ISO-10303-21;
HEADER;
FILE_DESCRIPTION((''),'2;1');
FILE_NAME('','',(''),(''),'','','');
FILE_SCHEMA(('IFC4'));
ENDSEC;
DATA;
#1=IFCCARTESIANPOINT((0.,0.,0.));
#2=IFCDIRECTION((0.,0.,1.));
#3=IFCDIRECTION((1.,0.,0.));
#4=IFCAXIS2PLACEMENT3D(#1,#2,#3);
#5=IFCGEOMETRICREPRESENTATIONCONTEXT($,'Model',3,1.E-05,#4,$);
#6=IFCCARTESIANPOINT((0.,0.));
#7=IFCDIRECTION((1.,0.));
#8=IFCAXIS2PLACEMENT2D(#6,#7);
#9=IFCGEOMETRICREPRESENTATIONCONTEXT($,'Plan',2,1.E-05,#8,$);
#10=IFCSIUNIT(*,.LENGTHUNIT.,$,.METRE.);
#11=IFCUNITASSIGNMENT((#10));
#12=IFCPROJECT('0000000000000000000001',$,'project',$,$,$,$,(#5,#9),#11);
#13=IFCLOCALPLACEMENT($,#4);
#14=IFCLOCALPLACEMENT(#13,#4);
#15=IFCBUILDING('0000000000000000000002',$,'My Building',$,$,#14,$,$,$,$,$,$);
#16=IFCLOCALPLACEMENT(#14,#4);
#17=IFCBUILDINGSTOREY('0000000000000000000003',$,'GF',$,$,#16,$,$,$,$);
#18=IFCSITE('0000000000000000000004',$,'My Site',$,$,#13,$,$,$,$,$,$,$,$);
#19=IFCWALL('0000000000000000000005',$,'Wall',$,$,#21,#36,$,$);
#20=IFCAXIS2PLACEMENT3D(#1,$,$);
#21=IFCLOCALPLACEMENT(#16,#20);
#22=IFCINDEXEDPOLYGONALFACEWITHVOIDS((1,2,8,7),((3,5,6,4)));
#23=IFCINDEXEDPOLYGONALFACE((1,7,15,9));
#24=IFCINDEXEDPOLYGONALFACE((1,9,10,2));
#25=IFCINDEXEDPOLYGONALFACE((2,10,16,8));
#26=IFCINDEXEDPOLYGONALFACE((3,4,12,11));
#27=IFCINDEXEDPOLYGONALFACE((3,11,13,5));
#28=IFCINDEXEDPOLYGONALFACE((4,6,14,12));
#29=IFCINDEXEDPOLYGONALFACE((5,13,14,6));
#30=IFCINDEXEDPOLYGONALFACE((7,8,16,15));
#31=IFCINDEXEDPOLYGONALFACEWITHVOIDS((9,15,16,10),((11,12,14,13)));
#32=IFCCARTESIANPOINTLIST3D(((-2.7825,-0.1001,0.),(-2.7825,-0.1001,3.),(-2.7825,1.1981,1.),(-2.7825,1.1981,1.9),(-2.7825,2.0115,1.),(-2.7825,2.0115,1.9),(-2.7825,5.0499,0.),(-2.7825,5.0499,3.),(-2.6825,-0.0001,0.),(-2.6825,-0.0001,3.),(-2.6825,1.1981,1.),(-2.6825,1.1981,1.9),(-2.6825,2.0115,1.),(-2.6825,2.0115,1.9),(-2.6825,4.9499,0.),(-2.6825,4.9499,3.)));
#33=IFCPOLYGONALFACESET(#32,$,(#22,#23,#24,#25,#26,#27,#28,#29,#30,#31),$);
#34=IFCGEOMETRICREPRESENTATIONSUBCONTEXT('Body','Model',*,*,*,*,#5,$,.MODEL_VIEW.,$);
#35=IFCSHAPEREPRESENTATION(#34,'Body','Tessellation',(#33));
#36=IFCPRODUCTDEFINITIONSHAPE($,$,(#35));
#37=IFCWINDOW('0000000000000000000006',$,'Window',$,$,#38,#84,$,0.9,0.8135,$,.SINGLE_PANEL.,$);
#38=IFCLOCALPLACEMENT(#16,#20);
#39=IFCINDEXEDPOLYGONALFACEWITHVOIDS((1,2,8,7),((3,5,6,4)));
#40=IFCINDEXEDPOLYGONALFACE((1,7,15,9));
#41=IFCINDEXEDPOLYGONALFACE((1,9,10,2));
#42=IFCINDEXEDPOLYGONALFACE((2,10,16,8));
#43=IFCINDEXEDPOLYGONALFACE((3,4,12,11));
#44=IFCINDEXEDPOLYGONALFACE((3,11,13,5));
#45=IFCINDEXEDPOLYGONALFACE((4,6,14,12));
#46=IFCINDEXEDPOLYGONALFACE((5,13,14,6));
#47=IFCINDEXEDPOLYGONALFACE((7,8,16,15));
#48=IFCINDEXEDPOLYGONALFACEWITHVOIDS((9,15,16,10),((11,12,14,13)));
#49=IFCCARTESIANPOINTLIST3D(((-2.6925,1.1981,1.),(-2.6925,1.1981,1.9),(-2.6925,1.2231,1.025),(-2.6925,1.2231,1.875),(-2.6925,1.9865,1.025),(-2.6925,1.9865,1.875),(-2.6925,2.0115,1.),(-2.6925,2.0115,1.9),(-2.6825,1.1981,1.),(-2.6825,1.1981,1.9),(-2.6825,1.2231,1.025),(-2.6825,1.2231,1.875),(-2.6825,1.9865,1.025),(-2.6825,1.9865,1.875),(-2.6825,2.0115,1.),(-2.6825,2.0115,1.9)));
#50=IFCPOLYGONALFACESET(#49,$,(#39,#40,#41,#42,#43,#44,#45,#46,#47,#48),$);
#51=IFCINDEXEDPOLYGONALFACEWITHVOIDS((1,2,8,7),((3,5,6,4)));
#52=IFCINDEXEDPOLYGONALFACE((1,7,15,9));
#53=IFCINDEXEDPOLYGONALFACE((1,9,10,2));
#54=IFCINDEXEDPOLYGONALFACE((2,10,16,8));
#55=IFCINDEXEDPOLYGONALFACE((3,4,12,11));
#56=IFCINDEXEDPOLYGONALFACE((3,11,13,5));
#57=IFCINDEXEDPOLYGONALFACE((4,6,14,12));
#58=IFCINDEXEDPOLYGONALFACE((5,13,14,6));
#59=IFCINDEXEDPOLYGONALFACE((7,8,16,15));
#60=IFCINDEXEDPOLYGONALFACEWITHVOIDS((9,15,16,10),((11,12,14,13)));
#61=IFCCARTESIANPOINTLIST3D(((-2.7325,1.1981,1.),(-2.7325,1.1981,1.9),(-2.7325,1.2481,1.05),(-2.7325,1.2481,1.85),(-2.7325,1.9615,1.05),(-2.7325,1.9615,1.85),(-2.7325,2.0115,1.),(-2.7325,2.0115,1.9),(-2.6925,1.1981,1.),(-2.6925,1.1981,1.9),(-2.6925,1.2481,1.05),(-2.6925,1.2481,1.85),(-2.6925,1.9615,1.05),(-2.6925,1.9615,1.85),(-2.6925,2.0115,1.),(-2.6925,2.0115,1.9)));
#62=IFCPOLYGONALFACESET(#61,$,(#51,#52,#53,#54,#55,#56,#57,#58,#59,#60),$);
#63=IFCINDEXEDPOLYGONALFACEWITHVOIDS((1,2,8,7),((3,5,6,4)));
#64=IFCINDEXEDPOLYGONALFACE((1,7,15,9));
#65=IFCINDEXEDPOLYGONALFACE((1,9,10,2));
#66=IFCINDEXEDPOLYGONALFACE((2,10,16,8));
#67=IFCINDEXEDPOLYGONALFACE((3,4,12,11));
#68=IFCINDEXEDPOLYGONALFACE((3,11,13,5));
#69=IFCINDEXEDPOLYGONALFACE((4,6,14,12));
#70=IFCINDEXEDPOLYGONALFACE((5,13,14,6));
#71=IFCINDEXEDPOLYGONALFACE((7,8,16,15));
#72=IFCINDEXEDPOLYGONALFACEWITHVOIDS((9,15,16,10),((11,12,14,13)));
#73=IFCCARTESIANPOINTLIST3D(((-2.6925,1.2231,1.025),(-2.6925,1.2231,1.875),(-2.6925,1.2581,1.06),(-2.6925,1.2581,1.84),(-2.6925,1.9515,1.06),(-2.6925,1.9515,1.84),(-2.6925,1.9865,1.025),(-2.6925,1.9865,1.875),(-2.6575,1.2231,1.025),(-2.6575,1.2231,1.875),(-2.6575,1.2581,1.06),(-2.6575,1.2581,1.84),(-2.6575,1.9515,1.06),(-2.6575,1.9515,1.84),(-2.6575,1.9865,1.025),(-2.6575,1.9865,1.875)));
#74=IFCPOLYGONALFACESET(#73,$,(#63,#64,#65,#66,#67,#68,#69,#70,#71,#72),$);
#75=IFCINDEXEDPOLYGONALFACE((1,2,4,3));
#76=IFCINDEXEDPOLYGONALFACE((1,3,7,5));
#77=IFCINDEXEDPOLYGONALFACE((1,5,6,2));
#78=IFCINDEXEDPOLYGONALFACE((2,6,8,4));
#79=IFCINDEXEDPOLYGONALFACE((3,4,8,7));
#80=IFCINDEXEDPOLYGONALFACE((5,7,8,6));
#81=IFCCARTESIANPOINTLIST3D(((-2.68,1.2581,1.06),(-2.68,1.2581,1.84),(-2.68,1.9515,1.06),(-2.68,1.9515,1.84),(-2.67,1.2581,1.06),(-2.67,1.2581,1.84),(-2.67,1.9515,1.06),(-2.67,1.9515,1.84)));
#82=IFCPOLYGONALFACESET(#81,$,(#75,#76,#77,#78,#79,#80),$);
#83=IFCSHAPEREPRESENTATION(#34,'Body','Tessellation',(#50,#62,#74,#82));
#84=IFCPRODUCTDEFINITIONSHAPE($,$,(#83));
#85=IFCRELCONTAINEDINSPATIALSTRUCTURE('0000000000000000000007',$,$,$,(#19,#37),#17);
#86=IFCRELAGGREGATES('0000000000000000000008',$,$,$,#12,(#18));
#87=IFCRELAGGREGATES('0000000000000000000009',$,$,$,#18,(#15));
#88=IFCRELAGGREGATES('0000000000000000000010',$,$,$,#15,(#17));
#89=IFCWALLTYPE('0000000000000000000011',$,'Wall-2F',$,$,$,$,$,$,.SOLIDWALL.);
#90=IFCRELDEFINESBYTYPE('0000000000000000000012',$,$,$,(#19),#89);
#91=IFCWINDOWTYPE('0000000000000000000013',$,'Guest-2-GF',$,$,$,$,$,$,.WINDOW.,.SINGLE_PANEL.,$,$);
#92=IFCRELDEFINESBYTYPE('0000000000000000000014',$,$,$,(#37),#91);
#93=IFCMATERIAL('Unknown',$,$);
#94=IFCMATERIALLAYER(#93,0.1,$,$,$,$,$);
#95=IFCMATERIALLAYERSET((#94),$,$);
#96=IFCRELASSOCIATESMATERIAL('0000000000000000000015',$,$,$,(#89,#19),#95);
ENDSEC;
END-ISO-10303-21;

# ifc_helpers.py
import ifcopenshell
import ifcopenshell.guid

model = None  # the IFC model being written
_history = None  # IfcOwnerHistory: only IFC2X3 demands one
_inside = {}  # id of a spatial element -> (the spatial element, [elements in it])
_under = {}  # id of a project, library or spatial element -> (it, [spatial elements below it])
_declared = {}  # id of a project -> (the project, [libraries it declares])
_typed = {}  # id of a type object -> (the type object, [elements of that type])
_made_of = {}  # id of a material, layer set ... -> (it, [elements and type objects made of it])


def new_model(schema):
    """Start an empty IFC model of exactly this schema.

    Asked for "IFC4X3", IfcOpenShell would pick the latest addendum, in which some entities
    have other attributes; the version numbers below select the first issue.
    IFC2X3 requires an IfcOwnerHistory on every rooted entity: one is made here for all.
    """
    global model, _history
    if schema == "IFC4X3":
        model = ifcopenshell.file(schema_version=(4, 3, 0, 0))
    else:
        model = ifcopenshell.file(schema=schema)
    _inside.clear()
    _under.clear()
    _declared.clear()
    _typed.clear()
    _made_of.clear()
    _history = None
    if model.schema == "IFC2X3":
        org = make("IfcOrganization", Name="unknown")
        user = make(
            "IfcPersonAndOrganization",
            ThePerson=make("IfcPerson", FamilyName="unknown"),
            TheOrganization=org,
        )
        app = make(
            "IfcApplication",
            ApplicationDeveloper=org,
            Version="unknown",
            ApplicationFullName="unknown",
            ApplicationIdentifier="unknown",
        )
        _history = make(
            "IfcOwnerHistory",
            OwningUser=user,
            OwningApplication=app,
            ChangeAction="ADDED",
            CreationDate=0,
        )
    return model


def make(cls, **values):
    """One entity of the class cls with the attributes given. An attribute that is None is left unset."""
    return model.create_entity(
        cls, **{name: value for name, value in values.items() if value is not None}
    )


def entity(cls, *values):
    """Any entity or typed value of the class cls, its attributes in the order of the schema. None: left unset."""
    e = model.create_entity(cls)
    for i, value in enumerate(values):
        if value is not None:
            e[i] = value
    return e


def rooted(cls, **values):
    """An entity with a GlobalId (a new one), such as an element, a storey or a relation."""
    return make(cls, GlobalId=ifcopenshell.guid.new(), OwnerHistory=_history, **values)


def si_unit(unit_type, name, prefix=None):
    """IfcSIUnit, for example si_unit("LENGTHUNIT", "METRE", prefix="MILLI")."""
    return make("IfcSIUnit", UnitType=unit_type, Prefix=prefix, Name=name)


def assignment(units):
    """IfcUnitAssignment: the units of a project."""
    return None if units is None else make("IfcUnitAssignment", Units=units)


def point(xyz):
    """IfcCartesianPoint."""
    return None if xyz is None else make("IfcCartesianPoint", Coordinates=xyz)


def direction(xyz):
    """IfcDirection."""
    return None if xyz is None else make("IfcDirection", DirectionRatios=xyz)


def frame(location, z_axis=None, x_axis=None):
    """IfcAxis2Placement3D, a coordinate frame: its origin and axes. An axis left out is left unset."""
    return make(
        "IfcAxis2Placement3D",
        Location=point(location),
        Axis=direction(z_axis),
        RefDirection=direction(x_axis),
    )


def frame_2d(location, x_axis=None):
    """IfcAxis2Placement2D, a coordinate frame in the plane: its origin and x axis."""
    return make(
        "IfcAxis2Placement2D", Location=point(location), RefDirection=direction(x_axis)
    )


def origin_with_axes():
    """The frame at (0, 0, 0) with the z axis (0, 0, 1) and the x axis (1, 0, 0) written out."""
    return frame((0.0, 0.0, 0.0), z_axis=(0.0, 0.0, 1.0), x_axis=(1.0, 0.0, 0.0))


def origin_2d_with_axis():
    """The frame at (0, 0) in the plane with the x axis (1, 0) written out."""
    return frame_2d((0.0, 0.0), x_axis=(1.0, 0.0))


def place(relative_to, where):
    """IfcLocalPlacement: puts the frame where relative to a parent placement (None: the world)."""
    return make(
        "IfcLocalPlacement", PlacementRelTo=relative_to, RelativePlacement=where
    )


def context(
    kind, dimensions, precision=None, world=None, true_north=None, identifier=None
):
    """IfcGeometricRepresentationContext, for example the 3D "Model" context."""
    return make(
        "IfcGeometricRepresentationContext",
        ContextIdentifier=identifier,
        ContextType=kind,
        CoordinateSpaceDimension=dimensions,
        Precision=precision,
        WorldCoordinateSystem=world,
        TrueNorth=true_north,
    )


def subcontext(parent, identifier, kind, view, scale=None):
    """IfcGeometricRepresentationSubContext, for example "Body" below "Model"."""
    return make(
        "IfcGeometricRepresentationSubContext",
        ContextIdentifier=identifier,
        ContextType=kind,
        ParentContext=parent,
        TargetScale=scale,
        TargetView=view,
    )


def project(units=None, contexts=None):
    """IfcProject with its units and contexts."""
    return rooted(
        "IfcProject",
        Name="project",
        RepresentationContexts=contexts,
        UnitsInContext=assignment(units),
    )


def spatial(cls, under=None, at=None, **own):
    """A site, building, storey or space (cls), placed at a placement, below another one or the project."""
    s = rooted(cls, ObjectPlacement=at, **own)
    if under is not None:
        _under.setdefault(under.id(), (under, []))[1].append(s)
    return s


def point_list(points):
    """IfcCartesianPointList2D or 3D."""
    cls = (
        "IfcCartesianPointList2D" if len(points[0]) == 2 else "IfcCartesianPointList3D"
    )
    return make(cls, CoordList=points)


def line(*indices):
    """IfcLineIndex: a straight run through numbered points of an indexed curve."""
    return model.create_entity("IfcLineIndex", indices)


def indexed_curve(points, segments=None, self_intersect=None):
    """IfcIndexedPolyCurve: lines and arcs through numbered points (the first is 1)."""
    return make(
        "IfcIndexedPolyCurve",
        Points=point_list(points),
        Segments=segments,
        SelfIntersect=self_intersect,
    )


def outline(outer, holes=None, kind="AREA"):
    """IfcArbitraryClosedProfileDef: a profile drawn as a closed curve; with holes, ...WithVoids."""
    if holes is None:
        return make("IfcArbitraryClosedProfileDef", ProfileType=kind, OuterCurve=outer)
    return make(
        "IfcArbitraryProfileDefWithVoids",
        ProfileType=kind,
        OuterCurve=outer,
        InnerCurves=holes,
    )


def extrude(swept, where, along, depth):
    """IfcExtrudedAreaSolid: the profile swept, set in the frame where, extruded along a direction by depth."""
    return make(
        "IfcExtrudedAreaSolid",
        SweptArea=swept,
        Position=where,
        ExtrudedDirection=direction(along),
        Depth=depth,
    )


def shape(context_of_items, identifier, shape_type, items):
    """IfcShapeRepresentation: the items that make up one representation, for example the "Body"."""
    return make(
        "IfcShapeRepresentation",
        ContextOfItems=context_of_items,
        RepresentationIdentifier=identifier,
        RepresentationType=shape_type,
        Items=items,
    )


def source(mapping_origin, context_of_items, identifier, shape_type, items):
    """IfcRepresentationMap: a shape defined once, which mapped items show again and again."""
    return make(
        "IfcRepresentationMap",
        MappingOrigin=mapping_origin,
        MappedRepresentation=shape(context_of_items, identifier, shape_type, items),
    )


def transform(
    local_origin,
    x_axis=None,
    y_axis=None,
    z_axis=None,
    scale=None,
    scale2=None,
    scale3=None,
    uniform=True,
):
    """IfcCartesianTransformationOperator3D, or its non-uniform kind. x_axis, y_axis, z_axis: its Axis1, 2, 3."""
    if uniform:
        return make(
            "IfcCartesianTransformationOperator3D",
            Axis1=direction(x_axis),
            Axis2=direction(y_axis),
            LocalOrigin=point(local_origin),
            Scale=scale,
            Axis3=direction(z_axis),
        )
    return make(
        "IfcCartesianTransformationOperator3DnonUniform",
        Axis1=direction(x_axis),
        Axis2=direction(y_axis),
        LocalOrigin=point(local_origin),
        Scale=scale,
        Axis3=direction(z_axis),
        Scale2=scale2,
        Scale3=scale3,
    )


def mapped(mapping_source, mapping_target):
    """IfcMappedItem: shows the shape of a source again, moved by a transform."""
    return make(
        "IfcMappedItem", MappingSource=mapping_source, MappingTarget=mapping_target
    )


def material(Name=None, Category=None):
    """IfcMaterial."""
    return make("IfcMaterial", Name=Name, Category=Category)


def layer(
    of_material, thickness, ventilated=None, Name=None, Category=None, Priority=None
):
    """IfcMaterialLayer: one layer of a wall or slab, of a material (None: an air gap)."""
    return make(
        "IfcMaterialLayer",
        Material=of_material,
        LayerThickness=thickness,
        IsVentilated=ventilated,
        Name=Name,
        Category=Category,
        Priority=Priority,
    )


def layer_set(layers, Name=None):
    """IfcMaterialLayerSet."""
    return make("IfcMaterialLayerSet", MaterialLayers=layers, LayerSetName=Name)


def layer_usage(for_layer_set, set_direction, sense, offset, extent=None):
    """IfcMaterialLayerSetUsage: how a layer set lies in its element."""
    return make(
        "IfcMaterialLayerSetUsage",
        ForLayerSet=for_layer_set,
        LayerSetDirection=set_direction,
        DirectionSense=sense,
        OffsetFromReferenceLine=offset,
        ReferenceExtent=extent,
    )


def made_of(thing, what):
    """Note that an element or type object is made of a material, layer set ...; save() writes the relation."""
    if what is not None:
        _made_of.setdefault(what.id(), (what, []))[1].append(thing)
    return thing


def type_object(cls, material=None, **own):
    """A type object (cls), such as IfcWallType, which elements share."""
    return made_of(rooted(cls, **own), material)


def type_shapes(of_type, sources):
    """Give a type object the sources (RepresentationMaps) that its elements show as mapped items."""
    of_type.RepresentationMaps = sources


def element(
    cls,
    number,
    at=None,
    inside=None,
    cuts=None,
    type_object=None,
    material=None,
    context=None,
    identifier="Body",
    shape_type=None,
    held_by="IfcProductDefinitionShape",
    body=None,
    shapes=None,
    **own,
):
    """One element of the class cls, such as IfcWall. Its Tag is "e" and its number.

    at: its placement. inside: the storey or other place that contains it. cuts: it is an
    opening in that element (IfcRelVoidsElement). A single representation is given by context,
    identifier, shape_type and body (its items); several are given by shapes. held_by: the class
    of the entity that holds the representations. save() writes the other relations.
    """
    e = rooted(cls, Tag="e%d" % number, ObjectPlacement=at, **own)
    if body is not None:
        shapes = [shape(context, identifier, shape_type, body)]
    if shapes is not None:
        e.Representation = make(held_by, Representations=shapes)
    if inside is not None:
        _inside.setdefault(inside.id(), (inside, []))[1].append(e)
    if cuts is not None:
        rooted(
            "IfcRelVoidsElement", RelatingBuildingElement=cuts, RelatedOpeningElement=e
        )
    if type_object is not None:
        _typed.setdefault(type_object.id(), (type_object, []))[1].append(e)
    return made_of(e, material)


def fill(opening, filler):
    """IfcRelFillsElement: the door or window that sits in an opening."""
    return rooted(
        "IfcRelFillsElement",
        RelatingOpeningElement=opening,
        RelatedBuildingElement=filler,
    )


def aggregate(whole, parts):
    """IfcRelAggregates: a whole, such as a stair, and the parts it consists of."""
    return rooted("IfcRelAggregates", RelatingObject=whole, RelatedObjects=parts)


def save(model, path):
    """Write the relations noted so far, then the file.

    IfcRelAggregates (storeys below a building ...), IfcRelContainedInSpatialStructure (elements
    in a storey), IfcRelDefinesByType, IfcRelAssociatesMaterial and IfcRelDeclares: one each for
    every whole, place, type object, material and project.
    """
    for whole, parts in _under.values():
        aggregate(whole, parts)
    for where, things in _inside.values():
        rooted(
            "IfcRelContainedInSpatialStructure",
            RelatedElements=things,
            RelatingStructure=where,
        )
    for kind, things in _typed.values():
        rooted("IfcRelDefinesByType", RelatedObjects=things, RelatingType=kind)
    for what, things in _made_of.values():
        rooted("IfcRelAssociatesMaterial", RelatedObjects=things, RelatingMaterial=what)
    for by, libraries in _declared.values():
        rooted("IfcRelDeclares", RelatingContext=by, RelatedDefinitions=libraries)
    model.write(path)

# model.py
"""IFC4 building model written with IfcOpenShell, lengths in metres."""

from ifc_helpers import new_model, entity, si_unit, frame, origin_with_axes, origin_2d_with_axis, place, context, subcontext, project, spatial, line, indexed_curve, outline, extrude, shape, source, transform, mapped, material, layer, layer_set, layer_usage, type_object, type_shapes, element, fill, save


model = new_model("IFC4")

# Units and contexts
model_context = context("Model", 3, precision=1e-05, world=origin_with_axes())
plan_context = context("Plan", 2, precision=1e-05, world=origin_2d_with_axis())
body_context_1 = subcontext(model_context, "Body", "Model", "MODEL_VIEW")
body_context_2 = subcontext(plan_context, "Body", "Plan", "PLAN_VIEW")
ifc_project = project(units=[si_unit("LENGTHUNIT", "METRE")], contexts=[model_context, plan_context])

# Site, building, storey
site_placement = place(None, origin_with_axes())
site = spatial("IfcSite", under=ifc_project, at=site_placement, Name="My Site")
building_placement = place(site_placement, origin_with_axes())
building = spatial("IfcBuilding", under=site, at=building_placement, Name="My Building")
storey_placement = place(building_placement, origin_with_axes())
storey = spatial("IfcBuildingStorey", under=building, at=storey_placement, Name="GF")

# Shared definitions
ifc_material = material(Name="Unknown")

# Shared definitions
ifc_layer_1 = layer(ifc_material, 0.1)
ifc_layer_set_1 = layer_set([ifc_layer_1])
wall_type = type_object("IfcWallType", Name="Wall-2F", PredefinedType="SOLIDWALL", material=ifc_layer_set_1)

# Wall, opening, window
ifc_layer_usage_1 = layer_usage(ifc_layer_set_1, "AXIS2", "POSITIVE", 0.0)
wall_1_placement = place(storey_placement, frame((-2.7825, 5.0499, 0.0), z_axis=(0.0, 0.0, 1.0), x_axis=(0.0, -1.0, 0.0)))
wall_1 = element("IfcWall", 1, at=wall_1_placement, inside=storey, type_object=wall_type, material=ifc_layer_usage_1, Name="Wall", context=body_context_1, shape_type="SweptSolid", body=[
    extrude(outline(indexed_curve([(0.0, 0.0), (0.1, 0.1), (5.05, 0.1), (5.15, 0.0)], segments=[line(1, 2, 3, 4, 1)])), origin_with_axes(), (0.0, 0.0, 1.0), 3.0),
])
shared_shape_1 = source(origin_with_axes(), body_context_1, "Body", "SweptSolid", [
    extrude(outline(indexed_curve([(0.0, 0.0), (0.8135, 0.0), (0.8135, 0.9), (0.0, 0.9)], segments=[line(1, 2, 3, 4, 1)])), frame((0.0, -0.6, 0.0), z_axis=(0.0, -1.0, 0.0), x_axis=(1.0, 0.0, 0.0)), (0.0, 0.0, -1.0), 1.2),
])
opening_1_placement = place(wall_1_placement, frame((3.0384, 0.0, 1.0), z_axis=(0.0, 0.0, 1.0), x_axis=(1.0, 0.0, 0.0)))
opening_1 = element("IfcOpeningElement", 2, at=opening_1_placement, cuts=wall_1, PredefinedType="OPENING", context=body_context_1, shape_type="MappedRepresentation", body=[
    mapped(shared_shape_1, transform((0.0, 0.0, 0.0), x_axis=(1.0, 0.0, 0.0), y_axis=(0.0, 1.0, 0.0), z_axis=(0.0, 0.0, 1.0), scale=1.0)),
])
window_type_1 = type_object("IfcWindowType", Name="Guest-2-GF", PartitioningType="SINGLE_PANEL", PredefinedType="WINDOW")
shared_shape_2 = source(origin_with_axes(), body_context_1, "Body", "SweptSolid", [
    extrude(outline(indexed_curve([(0.0, 0.0), (0.8135, 0.0), (0.8135, 0.9), (0.0, 0.9)], segments=[line(1, 2, 3, 4, 1)]), holes=[indexed_curve([(0.025, 0.025), (0.7885, 0.025), (0.7885, 0.875), (0.025, 0.875)], segments=[line(1, 2, 3, 4, 1)])]), frame((0.0, 0.09, 0.0), z_axis=(0.0, -1.0, 0.0), x_axis=(1.0, 0.0, 0.0)), (0.0, 0.0, -1.0), 0.01),
    extrude(outline(indexed_curve([(0.0, 0.0), (0.8135, 0.0), (0.8135, 0.9), (0.0, 0.9)], segments=[line(1, 2, 3, 4, 1)]), holes=[indexed_curve([(0.05, 0.05), (0.7635, 0.05), (0.7635, 0.85), (0.05, 0.85)], segments=[line(1, 2, 3, 4, 1)])]), frame((0.0, 0.05, 0.0), z_axis=(0.0, -1.0, 0.0), x_axis=(1.0, 0.0, 0.0)), (0.0, 0.0, -1.0), 0.04),
    extrude(outline(indexed_curve([(0.0, 0.0), (0.7635, 0.0), (0.7635, 0.85), (0.0, 0.85)], segments=[line(1, 2, 3, 4, 1)]), holes=[indexed_curve([(0.035, 0.035), (0.7285, 0.035), (0.7285, 0.815), (0.035, 0.815)], segments=[line(1, 2, 3, 4, 1)])]), frame((0.025, 0.09, 0.025), z_axis=(0.0, -1.0, 0.0), x_axis=(1.0, 0.0, 0.0)), (0.0, 0.0, -1.0), 0.035),
    extrude(outline(indexed_curve([(0.035, 0.035), (0.7285, 0.035), (0.7285, 0.815), (0.035, 0.815)], segments=[line(1, 2, 3, 4, 1)])), frame((0.025, 0.1025, 0.025), z_axis=(0.0, -1.0, 0.0), x_axis=(1.0, 0.0, 0.0)), (0.0, 0.0, -1.0), 0.01),
])
shared_shape_3 = source(origin_with_axes(), body_context_2, "Body", "Curve2D", [
    entity("IfcIndexedPolyCurve", entity("IfcCartesianPointList2D", [[0.05, 0.05], [0.7635, 0.05]])),
    entity("IfcIndexedPolyCurve", entity("IfcCartesianPointList2D", [[0.0, 0.1], [0.025, 0.1], [0.025, 0.09], [0.05, 0.09], [0.05, 0.05], [0.0, 0.05]]), [entity("IfcLineIndex", [1, 2, 3, 4, 5, 6, 1])]),
    entity("IfcIndexedPolyCurve", entity("IfcCartesianPointList2D", [[0.8135, 0.1], [0.7885, 0.1], [0.7885, 0.09], [0.7635, 0.09], [0.7635, 0.05], [0.8135, 0.05]]), [entity("IfcLineIndex", [1, 2, 3, 4, 5, 6, 1])]),
    entity("IfcIndexedPolyCurve", entity("IfcCartesianPointList2D", [[0.025, 0.09], [0.06, 0.09], [0.06, 0.125], [0.025, 0.125]]), [entity("IfcLineIndex", [1, 2, 3, 4, 1])]),
    entity("IfcIndexedPolyCurve", entity("IfcCartesianPointList2D", [[0.7885, 0.09], [0.7535, 0.09], [0.7535, 0.125], [0.7885, 0.125]]), [entity("IfcLineIndex", [1, 2, 3, 4, 1])]),
    entity("IfcIndexedPolyCurve", entity("IfcCartesianPointList2D", [[0.06, 0.09], [0.7535, 0.09]])),
    entity("IfcIndexedPolyCurve", entity("IfcCartesianPointList2D", [[0.06, 0.125], [0.7535, 0.125]])),
    entity("IfcIndexedPolyCurve", entity("IfcCartesianPointList2D", [[0.06, 0.1075], [0.7535, 0.1075]])),
])
type_shapes(window_type_1, [shared_shape_2, shared_shape_3])
window_1_placement = place(opening_1_placement, frame((0.0, 0.0, 0.0), z_axis=(0.0, 0.0, 1.0), x_axis=(1.0, 0.0, 0.0)))
window_1 = element("IfcWindow", 3, at=window_1_placement, inside=storey, type_object=window_type_1, Name="Window", OverallHeight=0.9, OverallWidth=0.8135, PartitioningType="SINGLE_PANEL", shapes=[
    shape(body_context_1, "Body", "MappedRepresentation", [mapped(shared_shape_2, transform((0.0, 0.0, 0.0), x_axis=(1.0, 0.0, 0.0), y_axis=(0.0, 1.0, 0.0), z_axis=(0.0, 0.0, 1.0), scale=1.0))]),
    shape(body_context_2, "Body", "MappedRepresentation", [mapped(shared_shape_3, transform((0.0, 0.0, 0.0), x_axis=(1.0, 0.0, 0.0), y_axis=(0.0, 1.0, 0.0), z_axis=(0.0, 0.0, 1.0), scale=1.0))]),
])
fill(opening_1, window_1)

save(model, "model.ifc")
